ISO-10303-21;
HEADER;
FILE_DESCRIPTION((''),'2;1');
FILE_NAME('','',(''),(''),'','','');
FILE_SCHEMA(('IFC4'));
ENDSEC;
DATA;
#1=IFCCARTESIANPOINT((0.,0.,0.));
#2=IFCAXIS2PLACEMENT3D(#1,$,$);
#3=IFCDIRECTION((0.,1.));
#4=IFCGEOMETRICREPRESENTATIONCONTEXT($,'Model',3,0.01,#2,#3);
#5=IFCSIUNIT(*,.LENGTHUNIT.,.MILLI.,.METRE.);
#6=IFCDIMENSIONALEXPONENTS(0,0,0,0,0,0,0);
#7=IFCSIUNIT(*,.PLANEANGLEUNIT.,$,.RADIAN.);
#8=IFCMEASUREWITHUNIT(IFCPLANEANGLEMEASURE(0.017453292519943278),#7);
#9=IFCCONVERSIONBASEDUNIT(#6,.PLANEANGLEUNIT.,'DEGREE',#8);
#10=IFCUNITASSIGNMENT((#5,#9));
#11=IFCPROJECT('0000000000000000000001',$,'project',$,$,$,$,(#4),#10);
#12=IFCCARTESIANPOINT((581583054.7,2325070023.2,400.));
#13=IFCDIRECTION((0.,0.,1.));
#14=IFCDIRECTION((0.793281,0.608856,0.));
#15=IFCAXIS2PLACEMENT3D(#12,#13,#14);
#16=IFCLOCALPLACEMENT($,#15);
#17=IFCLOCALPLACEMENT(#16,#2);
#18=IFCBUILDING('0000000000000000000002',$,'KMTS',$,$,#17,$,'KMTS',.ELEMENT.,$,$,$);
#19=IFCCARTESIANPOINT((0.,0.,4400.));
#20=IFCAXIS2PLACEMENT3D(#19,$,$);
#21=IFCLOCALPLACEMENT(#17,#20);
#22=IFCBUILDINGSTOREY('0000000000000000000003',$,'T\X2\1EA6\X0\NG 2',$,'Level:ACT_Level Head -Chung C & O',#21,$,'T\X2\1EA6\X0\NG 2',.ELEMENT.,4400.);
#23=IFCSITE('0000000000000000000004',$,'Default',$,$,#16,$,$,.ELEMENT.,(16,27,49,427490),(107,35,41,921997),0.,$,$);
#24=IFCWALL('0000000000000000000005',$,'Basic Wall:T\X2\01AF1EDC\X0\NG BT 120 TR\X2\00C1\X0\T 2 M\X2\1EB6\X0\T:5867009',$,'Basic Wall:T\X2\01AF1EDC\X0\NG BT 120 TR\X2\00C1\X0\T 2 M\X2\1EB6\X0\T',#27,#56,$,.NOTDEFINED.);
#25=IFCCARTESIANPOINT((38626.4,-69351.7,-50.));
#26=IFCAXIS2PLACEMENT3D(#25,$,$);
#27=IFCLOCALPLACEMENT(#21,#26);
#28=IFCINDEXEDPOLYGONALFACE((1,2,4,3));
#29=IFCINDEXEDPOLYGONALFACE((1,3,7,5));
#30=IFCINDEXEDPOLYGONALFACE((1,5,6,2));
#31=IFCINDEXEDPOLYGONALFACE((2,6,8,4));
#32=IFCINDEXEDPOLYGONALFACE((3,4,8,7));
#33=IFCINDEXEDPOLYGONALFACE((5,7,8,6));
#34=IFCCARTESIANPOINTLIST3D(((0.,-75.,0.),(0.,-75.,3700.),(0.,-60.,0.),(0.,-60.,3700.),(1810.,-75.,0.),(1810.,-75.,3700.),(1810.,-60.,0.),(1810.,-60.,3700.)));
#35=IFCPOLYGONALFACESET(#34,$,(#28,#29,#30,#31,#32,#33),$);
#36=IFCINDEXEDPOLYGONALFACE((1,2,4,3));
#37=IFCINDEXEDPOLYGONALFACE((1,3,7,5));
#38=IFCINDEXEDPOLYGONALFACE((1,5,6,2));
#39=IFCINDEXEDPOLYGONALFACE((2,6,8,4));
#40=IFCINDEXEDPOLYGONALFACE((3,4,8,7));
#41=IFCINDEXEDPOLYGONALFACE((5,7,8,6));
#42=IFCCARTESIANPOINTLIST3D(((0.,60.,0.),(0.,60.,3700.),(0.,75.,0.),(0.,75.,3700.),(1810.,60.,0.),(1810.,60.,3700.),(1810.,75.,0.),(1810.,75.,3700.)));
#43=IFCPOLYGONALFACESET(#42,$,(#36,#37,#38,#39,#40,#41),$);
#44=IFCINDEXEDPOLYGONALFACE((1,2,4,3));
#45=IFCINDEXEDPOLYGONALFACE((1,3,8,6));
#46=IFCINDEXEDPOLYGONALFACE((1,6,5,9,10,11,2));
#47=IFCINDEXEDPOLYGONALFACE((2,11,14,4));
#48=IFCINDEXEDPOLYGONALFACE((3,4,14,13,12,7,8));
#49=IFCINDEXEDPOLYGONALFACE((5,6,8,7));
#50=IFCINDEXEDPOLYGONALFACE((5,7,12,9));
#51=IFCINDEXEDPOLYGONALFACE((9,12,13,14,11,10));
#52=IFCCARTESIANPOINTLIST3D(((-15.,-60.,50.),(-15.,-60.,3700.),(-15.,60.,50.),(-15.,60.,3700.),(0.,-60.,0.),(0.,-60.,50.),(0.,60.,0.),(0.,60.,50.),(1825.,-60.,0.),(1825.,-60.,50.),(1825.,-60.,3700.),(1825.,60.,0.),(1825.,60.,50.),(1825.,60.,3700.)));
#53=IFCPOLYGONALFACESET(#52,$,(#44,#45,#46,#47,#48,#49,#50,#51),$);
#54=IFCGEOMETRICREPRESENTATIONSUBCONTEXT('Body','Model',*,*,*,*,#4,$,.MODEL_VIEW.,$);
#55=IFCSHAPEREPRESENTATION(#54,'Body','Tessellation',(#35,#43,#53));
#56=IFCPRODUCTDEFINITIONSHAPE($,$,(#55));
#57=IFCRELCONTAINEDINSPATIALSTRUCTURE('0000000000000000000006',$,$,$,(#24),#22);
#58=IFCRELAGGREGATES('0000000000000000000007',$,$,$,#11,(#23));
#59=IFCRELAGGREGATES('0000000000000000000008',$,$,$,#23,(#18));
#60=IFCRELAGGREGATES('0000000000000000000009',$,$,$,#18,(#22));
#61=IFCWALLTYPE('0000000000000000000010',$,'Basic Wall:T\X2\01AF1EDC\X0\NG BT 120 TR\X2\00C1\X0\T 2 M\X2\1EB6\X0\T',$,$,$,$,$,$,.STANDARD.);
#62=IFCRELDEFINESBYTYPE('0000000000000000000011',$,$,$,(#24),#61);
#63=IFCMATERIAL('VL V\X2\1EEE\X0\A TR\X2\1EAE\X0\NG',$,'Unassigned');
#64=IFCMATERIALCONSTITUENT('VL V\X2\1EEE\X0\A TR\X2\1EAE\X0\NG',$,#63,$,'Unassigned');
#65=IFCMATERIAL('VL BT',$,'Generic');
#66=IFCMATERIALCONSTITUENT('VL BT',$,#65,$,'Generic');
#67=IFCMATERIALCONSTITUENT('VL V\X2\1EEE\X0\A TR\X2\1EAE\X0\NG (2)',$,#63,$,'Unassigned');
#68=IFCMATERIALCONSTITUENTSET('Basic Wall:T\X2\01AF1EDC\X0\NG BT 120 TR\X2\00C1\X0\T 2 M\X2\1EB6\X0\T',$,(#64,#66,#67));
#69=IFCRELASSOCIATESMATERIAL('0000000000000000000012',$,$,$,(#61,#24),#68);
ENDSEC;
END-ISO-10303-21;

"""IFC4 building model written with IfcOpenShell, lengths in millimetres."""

from ifc_helpers import new_model, entity, si_unit, converted_unit, direction, frame, origin, place, context, subcontext, project, spatial, indexed_curve, outline, extrude, material, constituent, constituent_set, type_object, element, save


model = new_model("IFC4")

# Units and contexts
model_context = context("Model", 3, precision=0.01, world=origin(), true_north=direction((0.0, 1.0)))
body_context = subcontext(model_context, "Body", "Model", "MODEL_VIEW")
ifc_project = project(units=[si_unit("LENGTHUNIT", "METRE", prefix="MILLI"), converted_unit("PLANEANGLEUNIT", "DEGREE", entity("IfcPlaneAngleMeasure", 0.017453292519943278), si_unit("PLANEANGLEUNIT", "RADIAN"), dimensions=[0, 0, 0, 0, 0, 0, 0])], contexts=[model_context])

# Site, building, storey
site_placement = place(None, frame((581583054.7, 2325070023.2, 400.0), z_axis=(0.0, 0.0, 1.0), x_axis=(0.793281, 0.608856, 0.0)))
site = spatial("IfcSite", under=ifc_project, at=site_placement, Name="Default", CompositionType="ELEMENT", RefLatitude=(16, 27, 49, 427490), RefLongitude=(107, 35, 41, 921997), RefElevation=0.0)
building_placement = place(site_placement, origin())
building = spatial("IfcBuilding", under=site, at=building_placement, Name="KMTS", LongName="KMTS", CompositionType="ELEMENT")
storey_placement = place(building_placement, frame((0.0, 0.0, 4400.0)))
storey = spatial("IfcBuildingStorey", under=building, at=storey_placement, Name="TẦNG 2", ObjectType="Level:ACT_Level Head -Chung C & O", LongName="TẦNG 2", CompositionType="ELEMENT", Elevation=4400.0)

# Shared definitions
ifc_material_1 = material(Name="VL VỮA TRẮNG", Category="Unassigned")
ifc_material_2 = material(Name="VL BT", Category="Generic")

# Shared definitions
ifc_constituent_1 = constituent(ifc_material_1, Name="VL VỮA TRẮNG", Category="Unassigned")
ifc_constituent_2 = constituent(ifc_material_2, Name="VL BT", Category="Generic")
ifc_constituent_3 = constituent(ifc_material_1, Name="VL VỮA TRẮNG (2)", Category="Unassigned")
ifc_constituent_set_1 = constituent_set(constituents=[ifc_constituent_1, ifc_constituent_2, ifc_constituent_3], Name="Basic Wall:TƯỜNG BT 120 TRÁT 2 MẶT")
wall_type_1 = type_object("IfcWallType", Name="Basic Wall:TƯỜNG BT 120 TRÁT 2 MẶT", PredefinedType="STANDARD", material=ifc_constituent_set_1)

# Wall
wall_1_placement = place(storey_placement, frame((38626.4, -69351.7, -50.0)))
element("IfcWall", 1, at=wall_1_placement, inside=storey, type_object=wall_type_1, material=ifc_constituent_set_1, Name="Basic Wall:TƯỜNG BT 120 TRÁT 2 MẶT:5867009", ObjectType="Basic Wall:TƯỜNG BT 120 TRÁT 2 MẶT", PredefinedType="NOTDEFINED", context=body_context, shape_type="SweptSolid", body=[
    extrude(outline(indexed_curve([(-7.5, -905.0), (7.5, -905.0), (7.5, 905.0), (-7.5, 905.0), (-7.5, -905.0)], self_intersect=False)), frame((905.0, -67.5, 0.0), z_axis=(0.0, 0.0, 1.0), x_axis=(0.0, 1.0, 0.0)), (0.0, 0.0, 1.0), 3700.0),
    extrude(outline(indexed_curve([(-7.5, -905.0), (7.5, -905.0), (7.5, 905.0), (-7.5, 905.0), (-7.5, -905.0)], self_intersect=False)), frame((905.0, 67.5, 0.0), z_axis=(0.0, 0.0, 1.0), x_axis=(0.0, -1.0, 0.0)), (0.0, 0.0, 1.0), 3700.0),
    extrude(outline(indexed_curve([(-1078.6, 777.9), (-1078.6, -1047.1), (-1028.6, -1047.1), (2621.4, -1047.1), (2621.4, 792.9), (-1028.6, 792.9), (-1028.6, 777.9), (-1078.6, 777.9)], self_intersect=False)), frame((777.9, -60.0, 1078.6), z_axis=(0.0, -1.0, 0.0), x_axis=(0.0, 0.0, 1.0)), (0.0, 0.0, -1.0), 120.0),
])

save(model, "model.ifc")
